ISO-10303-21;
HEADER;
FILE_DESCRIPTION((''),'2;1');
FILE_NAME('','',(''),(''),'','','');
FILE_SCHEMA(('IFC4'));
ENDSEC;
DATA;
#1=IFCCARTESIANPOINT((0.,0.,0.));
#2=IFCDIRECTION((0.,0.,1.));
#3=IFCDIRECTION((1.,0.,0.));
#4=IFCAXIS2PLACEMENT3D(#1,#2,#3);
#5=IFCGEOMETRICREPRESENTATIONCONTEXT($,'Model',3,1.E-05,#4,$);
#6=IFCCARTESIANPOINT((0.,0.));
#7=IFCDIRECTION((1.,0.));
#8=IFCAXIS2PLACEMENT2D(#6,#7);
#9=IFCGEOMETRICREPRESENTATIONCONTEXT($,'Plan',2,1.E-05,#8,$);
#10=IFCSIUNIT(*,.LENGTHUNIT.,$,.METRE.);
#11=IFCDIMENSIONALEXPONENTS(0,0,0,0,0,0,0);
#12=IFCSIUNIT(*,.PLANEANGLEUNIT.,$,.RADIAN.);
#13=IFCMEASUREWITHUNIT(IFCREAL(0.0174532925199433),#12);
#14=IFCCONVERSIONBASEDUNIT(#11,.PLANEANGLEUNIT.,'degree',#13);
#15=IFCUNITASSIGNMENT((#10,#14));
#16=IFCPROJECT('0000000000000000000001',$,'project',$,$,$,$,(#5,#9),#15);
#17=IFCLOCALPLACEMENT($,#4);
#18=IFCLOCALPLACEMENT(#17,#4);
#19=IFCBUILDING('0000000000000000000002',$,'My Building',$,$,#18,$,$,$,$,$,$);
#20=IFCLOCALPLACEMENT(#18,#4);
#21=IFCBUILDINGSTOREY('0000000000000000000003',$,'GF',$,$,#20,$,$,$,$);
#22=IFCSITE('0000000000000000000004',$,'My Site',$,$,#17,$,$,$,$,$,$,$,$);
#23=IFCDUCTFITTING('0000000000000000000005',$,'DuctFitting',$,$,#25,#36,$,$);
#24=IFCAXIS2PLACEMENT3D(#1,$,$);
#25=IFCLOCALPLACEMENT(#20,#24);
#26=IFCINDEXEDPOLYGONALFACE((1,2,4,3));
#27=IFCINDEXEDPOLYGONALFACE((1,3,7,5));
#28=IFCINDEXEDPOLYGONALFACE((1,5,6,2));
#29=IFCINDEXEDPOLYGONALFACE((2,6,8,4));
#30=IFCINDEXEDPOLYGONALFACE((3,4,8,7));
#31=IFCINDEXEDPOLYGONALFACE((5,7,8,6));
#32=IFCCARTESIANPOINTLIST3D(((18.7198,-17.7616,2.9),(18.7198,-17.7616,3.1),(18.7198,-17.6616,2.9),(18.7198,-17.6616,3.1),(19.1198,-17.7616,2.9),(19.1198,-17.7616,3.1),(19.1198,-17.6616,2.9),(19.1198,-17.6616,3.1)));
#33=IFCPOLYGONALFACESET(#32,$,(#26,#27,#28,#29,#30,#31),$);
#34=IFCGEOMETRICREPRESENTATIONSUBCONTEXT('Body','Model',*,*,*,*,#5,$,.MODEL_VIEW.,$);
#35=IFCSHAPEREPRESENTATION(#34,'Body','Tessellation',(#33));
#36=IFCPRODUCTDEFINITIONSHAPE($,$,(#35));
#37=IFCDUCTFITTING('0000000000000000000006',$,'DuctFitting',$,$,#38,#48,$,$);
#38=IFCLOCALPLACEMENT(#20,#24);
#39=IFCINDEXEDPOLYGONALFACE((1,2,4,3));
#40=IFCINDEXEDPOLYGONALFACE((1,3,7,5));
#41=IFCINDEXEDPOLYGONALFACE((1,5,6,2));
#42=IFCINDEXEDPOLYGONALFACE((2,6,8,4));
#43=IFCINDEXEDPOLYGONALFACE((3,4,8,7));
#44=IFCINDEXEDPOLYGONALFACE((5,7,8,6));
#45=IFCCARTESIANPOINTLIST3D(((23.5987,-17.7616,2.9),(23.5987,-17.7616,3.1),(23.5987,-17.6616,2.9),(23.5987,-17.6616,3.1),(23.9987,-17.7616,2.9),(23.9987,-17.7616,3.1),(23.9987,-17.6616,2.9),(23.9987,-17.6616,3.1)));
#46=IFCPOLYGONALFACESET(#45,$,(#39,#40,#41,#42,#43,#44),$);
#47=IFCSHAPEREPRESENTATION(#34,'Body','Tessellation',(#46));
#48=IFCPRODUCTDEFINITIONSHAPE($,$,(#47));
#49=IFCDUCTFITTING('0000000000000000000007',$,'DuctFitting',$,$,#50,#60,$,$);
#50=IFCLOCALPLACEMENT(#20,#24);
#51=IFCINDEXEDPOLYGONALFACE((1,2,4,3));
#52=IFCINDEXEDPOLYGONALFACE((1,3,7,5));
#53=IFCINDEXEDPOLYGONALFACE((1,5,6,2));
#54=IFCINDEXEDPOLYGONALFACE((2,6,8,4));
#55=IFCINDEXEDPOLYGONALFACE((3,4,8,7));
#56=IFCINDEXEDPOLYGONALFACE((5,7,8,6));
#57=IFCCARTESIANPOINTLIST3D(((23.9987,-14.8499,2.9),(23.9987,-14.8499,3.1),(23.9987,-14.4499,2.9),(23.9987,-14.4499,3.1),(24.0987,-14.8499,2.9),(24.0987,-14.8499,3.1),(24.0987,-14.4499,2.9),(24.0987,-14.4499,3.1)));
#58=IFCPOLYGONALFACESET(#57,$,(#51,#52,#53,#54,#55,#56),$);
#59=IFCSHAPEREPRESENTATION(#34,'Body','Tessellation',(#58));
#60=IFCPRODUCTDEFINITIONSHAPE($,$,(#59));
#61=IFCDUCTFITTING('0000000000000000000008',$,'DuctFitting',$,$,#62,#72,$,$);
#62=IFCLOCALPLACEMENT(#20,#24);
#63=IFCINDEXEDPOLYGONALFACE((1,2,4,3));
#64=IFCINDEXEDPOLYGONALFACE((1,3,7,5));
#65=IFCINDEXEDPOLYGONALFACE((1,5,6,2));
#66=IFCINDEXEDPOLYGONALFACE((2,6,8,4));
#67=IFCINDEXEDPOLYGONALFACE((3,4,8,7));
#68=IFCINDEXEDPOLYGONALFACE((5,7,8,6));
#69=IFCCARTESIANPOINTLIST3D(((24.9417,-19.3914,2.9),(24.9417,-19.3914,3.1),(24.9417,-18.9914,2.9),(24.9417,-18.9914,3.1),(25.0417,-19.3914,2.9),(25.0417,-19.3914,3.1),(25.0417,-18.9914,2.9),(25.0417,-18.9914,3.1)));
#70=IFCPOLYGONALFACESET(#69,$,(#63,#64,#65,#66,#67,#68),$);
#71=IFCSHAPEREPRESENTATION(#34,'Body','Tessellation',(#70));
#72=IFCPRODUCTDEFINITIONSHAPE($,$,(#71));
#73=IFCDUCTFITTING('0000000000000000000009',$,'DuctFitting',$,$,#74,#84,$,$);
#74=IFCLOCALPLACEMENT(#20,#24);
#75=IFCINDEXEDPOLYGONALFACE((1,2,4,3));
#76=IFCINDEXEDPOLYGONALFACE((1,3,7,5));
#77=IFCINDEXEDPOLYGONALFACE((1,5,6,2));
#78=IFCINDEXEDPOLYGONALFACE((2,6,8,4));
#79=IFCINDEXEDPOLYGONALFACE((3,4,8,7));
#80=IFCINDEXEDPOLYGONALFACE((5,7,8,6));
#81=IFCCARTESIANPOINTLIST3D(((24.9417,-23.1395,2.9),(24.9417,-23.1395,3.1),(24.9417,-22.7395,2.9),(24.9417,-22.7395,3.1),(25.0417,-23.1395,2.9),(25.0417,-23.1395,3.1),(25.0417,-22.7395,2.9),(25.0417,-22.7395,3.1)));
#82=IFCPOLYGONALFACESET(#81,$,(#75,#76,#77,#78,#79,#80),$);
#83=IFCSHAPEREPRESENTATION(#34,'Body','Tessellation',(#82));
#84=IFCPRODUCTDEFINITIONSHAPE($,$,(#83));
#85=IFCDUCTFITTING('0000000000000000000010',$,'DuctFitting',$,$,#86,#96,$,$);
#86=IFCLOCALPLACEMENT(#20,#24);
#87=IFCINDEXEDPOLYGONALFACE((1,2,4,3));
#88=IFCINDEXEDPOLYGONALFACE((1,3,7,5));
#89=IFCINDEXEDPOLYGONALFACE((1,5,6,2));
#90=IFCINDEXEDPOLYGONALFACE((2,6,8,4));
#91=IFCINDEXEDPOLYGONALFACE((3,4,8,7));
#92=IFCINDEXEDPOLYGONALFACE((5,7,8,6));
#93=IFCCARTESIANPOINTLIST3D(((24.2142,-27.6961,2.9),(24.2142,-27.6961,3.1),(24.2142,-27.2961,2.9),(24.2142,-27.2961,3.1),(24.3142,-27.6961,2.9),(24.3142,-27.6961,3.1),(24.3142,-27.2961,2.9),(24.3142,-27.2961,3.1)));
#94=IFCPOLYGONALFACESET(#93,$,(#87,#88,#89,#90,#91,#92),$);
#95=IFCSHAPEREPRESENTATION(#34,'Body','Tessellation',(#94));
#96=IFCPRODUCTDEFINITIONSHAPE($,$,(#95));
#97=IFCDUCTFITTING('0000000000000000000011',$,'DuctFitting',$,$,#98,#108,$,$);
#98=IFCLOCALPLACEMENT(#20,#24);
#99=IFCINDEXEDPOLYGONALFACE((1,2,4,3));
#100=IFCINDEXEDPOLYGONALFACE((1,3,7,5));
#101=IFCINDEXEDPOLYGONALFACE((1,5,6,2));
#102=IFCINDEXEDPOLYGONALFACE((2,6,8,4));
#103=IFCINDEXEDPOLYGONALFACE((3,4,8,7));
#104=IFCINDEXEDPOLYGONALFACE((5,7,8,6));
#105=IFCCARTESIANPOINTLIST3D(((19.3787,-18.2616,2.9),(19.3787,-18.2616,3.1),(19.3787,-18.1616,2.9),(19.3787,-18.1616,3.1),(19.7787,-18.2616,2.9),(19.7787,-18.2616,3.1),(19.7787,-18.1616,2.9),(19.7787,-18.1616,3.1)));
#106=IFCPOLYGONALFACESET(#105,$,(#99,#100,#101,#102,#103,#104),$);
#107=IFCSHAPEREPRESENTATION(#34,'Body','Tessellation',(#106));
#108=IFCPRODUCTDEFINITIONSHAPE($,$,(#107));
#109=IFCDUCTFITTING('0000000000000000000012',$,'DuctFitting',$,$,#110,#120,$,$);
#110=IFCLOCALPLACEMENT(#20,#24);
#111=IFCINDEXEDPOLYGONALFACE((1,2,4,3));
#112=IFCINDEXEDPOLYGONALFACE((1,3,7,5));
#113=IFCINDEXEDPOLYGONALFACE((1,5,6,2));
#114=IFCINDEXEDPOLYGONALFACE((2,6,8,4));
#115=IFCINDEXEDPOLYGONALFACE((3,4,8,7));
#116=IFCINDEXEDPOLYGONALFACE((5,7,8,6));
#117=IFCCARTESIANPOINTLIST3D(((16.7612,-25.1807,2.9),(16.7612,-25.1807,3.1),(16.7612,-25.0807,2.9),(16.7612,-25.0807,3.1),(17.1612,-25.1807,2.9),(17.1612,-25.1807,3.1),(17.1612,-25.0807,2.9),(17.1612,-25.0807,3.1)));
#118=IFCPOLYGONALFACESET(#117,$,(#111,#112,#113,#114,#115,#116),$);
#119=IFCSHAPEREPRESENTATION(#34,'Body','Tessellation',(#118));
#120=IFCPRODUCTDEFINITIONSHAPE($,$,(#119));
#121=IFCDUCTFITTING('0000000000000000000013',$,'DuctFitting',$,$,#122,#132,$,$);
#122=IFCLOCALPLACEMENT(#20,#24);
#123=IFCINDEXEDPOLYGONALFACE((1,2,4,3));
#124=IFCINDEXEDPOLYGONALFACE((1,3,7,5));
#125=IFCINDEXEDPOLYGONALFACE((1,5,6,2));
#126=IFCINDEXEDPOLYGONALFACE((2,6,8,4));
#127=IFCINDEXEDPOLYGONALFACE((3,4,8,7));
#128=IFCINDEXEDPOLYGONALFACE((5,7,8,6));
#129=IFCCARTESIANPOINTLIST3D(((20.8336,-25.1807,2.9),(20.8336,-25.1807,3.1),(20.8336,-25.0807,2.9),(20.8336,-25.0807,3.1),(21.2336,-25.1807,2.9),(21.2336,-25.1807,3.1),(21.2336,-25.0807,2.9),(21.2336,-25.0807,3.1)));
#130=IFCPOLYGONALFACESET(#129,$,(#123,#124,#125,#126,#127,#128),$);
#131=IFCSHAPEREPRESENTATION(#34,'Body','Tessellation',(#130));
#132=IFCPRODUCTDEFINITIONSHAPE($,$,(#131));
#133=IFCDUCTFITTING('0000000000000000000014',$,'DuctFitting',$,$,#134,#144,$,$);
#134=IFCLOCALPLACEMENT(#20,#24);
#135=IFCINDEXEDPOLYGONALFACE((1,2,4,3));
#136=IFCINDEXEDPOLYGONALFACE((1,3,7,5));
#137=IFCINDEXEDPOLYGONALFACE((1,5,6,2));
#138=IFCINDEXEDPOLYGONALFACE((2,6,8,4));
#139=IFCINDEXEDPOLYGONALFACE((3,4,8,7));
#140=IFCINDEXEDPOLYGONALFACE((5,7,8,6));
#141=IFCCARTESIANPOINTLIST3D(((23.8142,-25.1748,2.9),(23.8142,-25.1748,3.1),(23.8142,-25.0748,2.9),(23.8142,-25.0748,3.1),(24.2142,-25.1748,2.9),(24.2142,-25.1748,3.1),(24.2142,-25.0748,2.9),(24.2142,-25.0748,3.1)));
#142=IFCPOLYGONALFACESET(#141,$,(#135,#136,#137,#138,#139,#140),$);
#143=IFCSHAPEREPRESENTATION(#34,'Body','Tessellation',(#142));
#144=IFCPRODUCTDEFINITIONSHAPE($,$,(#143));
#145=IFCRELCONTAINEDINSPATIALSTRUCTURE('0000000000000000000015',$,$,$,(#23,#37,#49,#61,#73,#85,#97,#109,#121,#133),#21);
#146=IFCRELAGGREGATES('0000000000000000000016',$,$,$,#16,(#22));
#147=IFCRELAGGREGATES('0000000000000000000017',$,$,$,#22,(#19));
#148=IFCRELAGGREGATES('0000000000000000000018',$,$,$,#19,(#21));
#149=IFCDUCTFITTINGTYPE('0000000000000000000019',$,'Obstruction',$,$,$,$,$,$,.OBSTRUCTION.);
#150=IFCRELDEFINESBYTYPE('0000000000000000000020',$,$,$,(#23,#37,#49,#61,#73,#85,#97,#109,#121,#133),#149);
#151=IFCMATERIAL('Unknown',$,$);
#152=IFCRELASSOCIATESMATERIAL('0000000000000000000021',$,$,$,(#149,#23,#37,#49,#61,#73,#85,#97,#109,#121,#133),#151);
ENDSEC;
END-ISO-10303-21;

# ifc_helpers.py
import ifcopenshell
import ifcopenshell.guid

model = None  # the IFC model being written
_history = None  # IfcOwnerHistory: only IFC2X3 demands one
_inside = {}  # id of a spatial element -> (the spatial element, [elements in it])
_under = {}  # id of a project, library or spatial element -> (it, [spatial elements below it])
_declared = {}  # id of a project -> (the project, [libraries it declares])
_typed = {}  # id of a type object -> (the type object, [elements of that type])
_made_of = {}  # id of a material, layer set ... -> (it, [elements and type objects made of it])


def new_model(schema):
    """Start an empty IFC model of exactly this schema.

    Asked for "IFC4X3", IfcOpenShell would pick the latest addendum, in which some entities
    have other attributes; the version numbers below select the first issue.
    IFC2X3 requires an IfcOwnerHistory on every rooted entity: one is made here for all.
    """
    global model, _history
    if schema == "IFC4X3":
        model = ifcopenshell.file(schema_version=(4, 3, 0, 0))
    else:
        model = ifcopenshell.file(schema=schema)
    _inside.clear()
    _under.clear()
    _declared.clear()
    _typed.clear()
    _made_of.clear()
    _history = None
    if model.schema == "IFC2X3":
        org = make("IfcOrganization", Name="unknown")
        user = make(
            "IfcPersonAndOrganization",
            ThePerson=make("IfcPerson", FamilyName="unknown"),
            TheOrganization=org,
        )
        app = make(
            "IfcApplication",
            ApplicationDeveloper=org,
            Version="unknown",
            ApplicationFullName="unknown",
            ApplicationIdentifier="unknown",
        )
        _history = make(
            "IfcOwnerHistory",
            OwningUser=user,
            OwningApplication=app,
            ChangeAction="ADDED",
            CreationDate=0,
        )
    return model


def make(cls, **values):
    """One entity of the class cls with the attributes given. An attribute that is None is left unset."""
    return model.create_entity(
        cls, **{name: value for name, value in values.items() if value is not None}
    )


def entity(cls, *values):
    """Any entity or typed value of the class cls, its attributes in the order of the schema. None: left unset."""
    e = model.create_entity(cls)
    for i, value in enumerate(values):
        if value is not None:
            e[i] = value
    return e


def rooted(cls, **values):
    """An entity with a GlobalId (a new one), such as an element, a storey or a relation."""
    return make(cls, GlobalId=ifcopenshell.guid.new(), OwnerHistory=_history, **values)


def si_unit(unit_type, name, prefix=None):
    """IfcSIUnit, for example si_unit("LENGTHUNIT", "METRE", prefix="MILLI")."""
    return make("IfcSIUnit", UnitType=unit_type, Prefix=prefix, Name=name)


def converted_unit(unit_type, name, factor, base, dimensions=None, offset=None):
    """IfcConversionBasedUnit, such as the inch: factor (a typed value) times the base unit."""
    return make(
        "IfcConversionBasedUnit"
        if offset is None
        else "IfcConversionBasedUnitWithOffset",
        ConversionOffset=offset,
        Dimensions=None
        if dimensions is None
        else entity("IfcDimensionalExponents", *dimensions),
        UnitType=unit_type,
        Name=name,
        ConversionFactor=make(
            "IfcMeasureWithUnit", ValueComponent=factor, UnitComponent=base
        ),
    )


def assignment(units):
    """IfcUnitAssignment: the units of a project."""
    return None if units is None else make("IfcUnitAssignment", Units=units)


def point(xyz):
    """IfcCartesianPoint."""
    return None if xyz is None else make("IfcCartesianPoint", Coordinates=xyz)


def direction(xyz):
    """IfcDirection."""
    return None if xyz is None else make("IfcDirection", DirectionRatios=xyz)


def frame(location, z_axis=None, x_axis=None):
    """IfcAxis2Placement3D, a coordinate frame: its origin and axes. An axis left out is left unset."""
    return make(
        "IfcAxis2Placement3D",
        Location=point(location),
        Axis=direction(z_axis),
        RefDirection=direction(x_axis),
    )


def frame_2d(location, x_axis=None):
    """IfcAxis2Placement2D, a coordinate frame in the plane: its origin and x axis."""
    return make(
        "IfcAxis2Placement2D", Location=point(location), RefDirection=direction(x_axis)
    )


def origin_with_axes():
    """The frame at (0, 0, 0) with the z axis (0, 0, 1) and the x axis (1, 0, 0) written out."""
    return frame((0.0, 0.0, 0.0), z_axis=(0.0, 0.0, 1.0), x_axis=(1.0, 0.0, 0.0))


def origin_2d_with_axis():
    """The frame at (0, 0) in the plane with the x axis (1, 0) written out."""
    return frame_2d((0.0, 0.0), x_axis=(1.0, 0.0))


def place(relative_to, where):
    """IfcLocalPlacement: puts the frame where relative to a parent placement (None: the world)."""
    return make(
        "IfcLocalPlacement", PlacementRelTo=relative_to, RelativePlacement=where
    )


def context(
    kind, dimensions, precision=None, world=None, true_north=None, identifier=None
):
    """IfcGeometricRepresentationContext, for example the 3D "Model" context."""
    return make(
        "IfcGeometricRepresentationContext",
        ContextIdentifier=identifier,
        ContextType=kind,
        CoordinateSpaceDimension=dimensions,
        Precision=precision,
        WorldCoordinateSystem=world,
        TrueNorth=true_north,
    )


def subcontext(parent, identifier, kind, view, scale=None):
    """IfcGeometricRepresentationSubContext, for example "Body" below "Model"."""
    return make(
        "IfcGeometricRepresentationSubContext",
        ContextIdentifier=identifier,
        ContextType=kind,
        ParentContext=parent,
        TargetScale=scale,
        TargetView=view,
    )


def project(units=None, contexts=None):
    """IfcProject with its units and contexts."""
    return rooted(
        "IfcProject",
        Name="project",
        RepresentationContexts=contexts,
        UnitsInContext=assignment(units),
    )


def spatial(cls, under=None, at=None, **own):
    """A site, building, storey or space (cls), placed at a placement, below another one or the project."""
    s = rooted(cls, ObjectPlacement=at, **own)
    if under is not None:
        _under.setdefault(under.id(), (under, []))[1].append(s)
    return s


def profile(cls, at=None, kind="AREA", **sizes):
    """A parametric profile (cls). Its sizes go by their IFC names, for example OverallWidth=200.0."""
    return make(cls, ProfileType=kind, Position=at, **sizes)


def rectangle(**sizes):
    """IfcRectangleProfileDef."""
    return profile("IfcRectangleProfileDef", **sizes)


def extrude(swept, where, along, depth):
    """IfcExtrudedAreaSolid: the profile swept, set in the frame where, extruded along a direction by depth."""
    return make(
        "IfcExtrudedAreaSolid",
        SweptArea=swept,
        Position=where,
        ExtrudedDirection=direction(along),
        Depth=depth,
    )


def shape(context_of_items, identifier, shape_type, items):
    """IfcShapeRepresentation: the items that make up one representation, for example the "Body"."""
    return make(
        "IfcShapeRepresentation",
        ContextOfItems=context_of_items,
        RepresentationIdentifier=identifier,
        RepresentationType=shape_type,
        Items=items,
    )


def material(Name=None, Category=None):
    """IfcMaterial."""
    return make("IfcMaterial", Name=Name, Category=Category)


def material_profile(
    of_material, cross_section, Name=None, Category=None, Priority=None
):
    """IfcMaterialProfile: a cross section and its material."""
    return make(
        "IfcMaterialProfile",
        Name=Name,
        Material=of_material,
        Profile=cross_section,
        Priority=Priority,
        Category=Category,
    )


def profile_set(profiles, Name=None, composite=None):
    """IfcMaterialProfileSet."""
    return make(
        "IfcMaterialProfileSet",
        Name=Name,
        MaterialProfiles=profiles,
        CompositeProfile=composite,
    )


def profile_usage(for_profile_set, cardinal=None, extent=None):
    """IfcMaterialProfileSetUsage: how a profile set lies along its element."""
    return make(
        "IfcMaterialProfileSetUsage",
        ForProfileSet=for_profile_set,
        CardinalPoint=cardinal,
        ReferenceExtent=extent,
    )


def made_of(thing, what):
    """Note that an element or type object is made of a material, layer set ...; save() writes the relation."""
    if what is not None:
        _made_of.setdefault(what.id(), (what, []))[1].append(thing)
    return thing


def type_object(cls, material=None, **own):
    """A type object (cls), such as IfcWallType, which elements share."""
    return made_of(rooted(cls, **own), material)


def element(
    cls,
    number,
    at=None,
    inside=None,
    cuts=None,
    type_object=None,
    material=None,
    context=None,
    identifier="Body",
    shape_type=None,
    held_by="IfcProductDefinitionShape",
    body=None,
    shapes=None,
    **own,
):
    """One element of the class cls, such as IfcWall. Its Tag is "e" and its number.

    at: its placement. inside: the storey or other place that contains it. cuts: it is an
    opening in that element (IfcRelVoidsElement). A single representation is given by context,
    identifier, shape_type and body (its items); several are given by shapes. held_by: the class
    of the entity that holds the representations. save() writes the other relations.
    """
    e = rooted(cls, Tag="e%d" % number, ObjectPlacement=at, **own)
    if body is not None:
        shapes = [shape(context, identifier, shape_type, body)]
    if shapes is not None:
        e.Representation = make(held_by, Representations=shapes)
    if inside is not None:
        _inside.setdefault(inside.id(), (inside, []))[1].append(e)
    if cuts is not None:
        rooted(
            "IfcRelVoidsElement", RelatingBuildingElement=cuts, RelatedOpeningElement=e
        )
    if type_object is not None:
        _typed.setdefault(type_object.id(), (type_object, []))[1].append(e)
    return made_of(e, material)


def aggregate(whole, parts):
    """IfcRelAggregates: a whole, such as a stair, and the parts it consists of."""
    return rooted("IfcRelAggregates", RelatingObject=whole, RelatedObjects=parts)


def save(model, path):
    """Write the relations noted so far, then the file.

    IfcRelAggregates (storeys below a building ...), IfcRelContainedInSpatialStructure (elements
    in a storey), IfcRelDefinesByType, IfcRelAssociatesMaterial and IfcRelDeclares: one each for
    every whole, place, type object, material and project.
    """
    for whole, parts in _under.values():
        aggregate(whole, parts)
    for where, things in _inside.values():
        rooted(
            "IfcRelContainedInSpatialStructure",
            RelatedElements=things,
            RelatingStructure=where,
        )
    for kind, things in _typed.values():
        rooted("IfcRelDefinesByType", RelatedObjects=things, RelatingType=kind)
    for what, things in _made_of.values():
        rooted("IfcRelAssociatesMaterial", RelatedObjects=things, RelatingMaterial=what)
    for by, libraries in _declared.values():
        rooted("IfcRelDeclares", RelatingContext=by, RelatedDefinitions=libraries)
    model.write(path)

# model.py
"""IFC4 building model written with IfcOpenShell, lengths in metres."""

from ifc_helpers import new_model, entity, si_unit, converted_unit, frame, origin_with_axes, origin_2d_with_axis, place, context, subcontext, project, spatial, rectangle, extrude, material, material_profile, profile_set, profile_usage, type_object, element, save


model = new_model("IFC4")

# Units and contexts
model_context = context("Model", 3, precision=1e-05, world=origin_with_axes())
plan_context = context("Plan", 2, precision=1e-05, world=origin_2d_with_axis())
body_context_1 = subcontext(model_context, "Body", "Model", "MODEL_VIEW")
ifc_project = project(units=[si_unit("LENGTHUNIT", "METRE"), converted_unit("PLANEANGLEUNIT", "degree", entity("IfcReal", 0.0174532925199433), si_unit("PLANEANGLEUNIT", "RADIAN"), dimensions=[0, 0, 0, 0, 0, 0, 0])], contexts=[model_context, plan_context])

# Site, building, storey
site_placement = place(None, origin_with_axes())
site = spatial("IfcSite", under=ifc_project, at=site_placement, Name="My Site")
building_placement = place(site_placement, origin_with_axes())
building = spatial("IfcBuilding", under=site, at=building_placement, Name="My Building")
storey_placement = place(building_placement, origin_with_axes())
storey = spatial("IfcBuildingStorey", under=building, at=storey_placement, Name="GF")

# Shared definitions
ifc_material = material(Name="Unknown")

# Duct fittings
ifc_material_profile = material_profile(ifc_material, rectangle(XDim=0.4, YDim=0.2))
ifc_profile_set = profile_set([ifc_material_profile])
duct_fitting_type = type_object("IfcDuctFittingType", Name="Obstruction", PredefinedType="OBSTRUCTION", material=ifc_profile_set)
ifc_profile_usage_1 = profile_usage(ifc_profile_set, cardinal=5)
duct_fitting_1_placement = place(storey_placement, frame((18.9198, -17.7616, 3.0), z_axis=(0.0, 1.0, 0.0), x_axis=(-1.0, 0.0, 0.0)))
element("IfcDuctFitting", 1, at=duct_fitting_1_placement, inside=storey, type_object=duct_fitting_type, material=ifc_profile_usage_1, Name="DuctFitting", context=body_context_1, shape_type="SweptSolid", body=[
    extrude(rectangle(XDim=0.4, YDim=0.2), origin_with_axes(), (0.0, 0.0, 1.0), 0.1),
])
ifc_profile_usage_2 = profile_usage(ifc_profile_set, cardinal=5)
duct_fitting_2_placement = place(storey_placement, frame((23.7987, -17.7616, 3.0), z_axis=(0.0, 1.0, 0.0), x_axis=(-1.0, 0.0, 0.0)))
element("IfcDuctFitting", 2, at=duct_fitting_2_placement, inside=storey, type_object=duct_fitting_type, material=ifc_profile_usage_2, Name="DuctFitting", context=body_context_1, shape_type="SweptSolid", body=[
    extrude(rectangle(XDim=0.4, YDim=0.2), origin_with_axes(), (0.0, 0.0, 1.0), 0.1),
])
ifc_profile_usage_3 = profile_usage(ifc_profile_set, cardinal=5)
duct_fitting_3_placement = place(storey_placement, frame((23.9987, -14.6499, 3.0), z_axis=(1.0, 0.0, 0.0), x_axis=(0.0, 1.0, 0.0)))
element("IfcDuctFitting", 3, at=duct_fitting_3_placement, inside=storey, type_object=duct_fitting_type, material=ifc_profile_usage_3, Name="DuctFitting", context=body_context_1, shape_type="SweptSolid", body=[
    extrude(rectangle(XDim=0.4, YDim=0.2), origin_with_axes(), (0.0, 0.0, 1.0), 0.1),
])
ifc_profile_usage_4 = profile_usage(ifc_profile_set, cardinal=5)
duct_fitting_4_placement = place(storey_placement, frame((24.9417, -19.1914, 3.0), z_axis=(1.0, 0.0, 0.0), x_axis=(0.0, 1.0, 0.0)))
element("IfcDuctFitting", 4, at=duct_fitting_4_placement, inside=storey, type_object=duct_fitting_type, material=ifc_profile_usage_4, Name="DuctFitting", context=body_context_1, shape_type="SweptSolid", body=[
    extrude(rectangle(XDim=0.4, YDim=0.2), origin_with_axes(), (0.0, 0.0, 1.0), 0.1),
])
ifc_profile_usage_5 = profile_usage(ifc_profile_set, cardinal=5)
duct_fitting_5_placement = place(storey_placement, frame((24.9417, -22.9395, 3.0), z_axis=(1.0, 0.0, 0.0), x_axis=(0.0, 1.0, 0.0)))
element("IfcDuctFitting", 5, at=duct_fitting_5_placement, inside=storey, type_object=duct_fitting_type, material=ifc_profile_usage_5, Name="DuctFitting", context=body_context_1, shape_type="SweptSolid", body=[
    extrude(rectangle(XDim=0.4, YDim=0.2), origin_with_axes(), (0.0, 0.0, 1.0), 0.1),
])
ifc_profile_usage_6 = profile_usage(ifc_profile_set, cardinal=5)
duct_fitting_6_placement = place(storey_placement, frame((24.2142, -27.4961, 3.0), z_axis=(1.0, 0.0, 0.0), x_axis=(0.0, 1.0, 0.0)))
element("IfcDuctFitting", 6, at=duct_fitting_6_placement, inside=storey, type_object=duct_fitting_type, material=ifc_profile_usage_6, Name="DuctFitting", context=body_context_1, shape_type="SweptSolid", body=[
    extrude(rectangle(XDim=0.4, YDim=0.2), origin_with_axes(), (0.0, 0.0, 1.0), 0.1),
])
ifc_profile_usage_7 = profile_usage(ifc_profile_set, cardinal=5)
duct_fitting_7_placement = place(storey_placement, frame((19.5787, -18.1616, 3.0), z_axis=(0.0, -1.0, 0.0), x_axis=(1.0, 0.0, 0.0)))
element("IfcDuctFitting", 7, at=duct_fitting_7_placement, inside=storey, type_object=duct_fitting_type, material=ifc_profile_usage_7, Name="DuctFitting", context=body_context_1, shape_type="SweptSolid", body=[
    extrude(rectangle(XDim=0.4, YDim=0.2), origin_with_axes(), (0.0, 0.0, 1.0), 0.1),
])
ifc_profile_usage_8 = profile_usage(ifc_profile_set, cardinal=5)
duct_fitting_8_placement = place(storey_placement, frame((16.9612, -25.0807, 3.0), z_axis=(0.0, -1.0, 0.0), x_axis=(1.0, 0.0, 0.0)))
element("IfcDuctFitting", 8, at=duct_fitting_8_placement, inside=storey, type_object=duct_fitting_type, material=ifc_profile_usage_8, Name="DuctFitting", context=body_context_1, shape_type="SweptSolid", body=[
    extrude(rectangle(XDim=0.4, YDim=0.2), origin_with_axes(), (0.0, 0.0, 1.0), 0.1),
])
ifc_profile_usage_9 = profile_usage(ifc_profile_set, cardinal=5)
duct_fitting_9_placement = place(storey_placement, frame((21.0336, -25.0807, 3.0), z_axis=(0.0, -1.0, 0.0), x_axis=(1.0, 0.0, 0.0)))
element("IfcDuctFitting", 9, at=duct_fitting_9_placement, inside=storey, type_object=duct_fitting_type, material=ifc_profile_usage_9, Name="DuctFitting", context=body_context_1, shape_type="SweptSolid", body=[
    extrude(rectangle(XDim=0.4, YDim=0.2), origin_with_axes(), (0.0, 0.0, 1.0), 0.1),
])
ifc_profile_usage_10 = profile_usage(ifc_profile_set, cardinal=5)
duct_fitting_10_placement = place(storey_placement, frame((24.0142, -25.0748, 3.0), z_axis=(0.0, -1.0, 0.0), x_axis=(1.0, 0.0, 0.0)))
element("IfcDuctFitting", 10, at=duct_fitting_10_placement, inside=storey, type_object=duct_fitting_type, material=ifc_profile_usage_10, Name="DuctFitting", context=body_context_1, shape_type="SweptSolid", body=[
    extrude(rectangle(XDim=0.4, YDim=0.2), origin_with_axes(), (0.0, 0.0, 1.0), 0.1),
])

save(model, "model.ifc")
